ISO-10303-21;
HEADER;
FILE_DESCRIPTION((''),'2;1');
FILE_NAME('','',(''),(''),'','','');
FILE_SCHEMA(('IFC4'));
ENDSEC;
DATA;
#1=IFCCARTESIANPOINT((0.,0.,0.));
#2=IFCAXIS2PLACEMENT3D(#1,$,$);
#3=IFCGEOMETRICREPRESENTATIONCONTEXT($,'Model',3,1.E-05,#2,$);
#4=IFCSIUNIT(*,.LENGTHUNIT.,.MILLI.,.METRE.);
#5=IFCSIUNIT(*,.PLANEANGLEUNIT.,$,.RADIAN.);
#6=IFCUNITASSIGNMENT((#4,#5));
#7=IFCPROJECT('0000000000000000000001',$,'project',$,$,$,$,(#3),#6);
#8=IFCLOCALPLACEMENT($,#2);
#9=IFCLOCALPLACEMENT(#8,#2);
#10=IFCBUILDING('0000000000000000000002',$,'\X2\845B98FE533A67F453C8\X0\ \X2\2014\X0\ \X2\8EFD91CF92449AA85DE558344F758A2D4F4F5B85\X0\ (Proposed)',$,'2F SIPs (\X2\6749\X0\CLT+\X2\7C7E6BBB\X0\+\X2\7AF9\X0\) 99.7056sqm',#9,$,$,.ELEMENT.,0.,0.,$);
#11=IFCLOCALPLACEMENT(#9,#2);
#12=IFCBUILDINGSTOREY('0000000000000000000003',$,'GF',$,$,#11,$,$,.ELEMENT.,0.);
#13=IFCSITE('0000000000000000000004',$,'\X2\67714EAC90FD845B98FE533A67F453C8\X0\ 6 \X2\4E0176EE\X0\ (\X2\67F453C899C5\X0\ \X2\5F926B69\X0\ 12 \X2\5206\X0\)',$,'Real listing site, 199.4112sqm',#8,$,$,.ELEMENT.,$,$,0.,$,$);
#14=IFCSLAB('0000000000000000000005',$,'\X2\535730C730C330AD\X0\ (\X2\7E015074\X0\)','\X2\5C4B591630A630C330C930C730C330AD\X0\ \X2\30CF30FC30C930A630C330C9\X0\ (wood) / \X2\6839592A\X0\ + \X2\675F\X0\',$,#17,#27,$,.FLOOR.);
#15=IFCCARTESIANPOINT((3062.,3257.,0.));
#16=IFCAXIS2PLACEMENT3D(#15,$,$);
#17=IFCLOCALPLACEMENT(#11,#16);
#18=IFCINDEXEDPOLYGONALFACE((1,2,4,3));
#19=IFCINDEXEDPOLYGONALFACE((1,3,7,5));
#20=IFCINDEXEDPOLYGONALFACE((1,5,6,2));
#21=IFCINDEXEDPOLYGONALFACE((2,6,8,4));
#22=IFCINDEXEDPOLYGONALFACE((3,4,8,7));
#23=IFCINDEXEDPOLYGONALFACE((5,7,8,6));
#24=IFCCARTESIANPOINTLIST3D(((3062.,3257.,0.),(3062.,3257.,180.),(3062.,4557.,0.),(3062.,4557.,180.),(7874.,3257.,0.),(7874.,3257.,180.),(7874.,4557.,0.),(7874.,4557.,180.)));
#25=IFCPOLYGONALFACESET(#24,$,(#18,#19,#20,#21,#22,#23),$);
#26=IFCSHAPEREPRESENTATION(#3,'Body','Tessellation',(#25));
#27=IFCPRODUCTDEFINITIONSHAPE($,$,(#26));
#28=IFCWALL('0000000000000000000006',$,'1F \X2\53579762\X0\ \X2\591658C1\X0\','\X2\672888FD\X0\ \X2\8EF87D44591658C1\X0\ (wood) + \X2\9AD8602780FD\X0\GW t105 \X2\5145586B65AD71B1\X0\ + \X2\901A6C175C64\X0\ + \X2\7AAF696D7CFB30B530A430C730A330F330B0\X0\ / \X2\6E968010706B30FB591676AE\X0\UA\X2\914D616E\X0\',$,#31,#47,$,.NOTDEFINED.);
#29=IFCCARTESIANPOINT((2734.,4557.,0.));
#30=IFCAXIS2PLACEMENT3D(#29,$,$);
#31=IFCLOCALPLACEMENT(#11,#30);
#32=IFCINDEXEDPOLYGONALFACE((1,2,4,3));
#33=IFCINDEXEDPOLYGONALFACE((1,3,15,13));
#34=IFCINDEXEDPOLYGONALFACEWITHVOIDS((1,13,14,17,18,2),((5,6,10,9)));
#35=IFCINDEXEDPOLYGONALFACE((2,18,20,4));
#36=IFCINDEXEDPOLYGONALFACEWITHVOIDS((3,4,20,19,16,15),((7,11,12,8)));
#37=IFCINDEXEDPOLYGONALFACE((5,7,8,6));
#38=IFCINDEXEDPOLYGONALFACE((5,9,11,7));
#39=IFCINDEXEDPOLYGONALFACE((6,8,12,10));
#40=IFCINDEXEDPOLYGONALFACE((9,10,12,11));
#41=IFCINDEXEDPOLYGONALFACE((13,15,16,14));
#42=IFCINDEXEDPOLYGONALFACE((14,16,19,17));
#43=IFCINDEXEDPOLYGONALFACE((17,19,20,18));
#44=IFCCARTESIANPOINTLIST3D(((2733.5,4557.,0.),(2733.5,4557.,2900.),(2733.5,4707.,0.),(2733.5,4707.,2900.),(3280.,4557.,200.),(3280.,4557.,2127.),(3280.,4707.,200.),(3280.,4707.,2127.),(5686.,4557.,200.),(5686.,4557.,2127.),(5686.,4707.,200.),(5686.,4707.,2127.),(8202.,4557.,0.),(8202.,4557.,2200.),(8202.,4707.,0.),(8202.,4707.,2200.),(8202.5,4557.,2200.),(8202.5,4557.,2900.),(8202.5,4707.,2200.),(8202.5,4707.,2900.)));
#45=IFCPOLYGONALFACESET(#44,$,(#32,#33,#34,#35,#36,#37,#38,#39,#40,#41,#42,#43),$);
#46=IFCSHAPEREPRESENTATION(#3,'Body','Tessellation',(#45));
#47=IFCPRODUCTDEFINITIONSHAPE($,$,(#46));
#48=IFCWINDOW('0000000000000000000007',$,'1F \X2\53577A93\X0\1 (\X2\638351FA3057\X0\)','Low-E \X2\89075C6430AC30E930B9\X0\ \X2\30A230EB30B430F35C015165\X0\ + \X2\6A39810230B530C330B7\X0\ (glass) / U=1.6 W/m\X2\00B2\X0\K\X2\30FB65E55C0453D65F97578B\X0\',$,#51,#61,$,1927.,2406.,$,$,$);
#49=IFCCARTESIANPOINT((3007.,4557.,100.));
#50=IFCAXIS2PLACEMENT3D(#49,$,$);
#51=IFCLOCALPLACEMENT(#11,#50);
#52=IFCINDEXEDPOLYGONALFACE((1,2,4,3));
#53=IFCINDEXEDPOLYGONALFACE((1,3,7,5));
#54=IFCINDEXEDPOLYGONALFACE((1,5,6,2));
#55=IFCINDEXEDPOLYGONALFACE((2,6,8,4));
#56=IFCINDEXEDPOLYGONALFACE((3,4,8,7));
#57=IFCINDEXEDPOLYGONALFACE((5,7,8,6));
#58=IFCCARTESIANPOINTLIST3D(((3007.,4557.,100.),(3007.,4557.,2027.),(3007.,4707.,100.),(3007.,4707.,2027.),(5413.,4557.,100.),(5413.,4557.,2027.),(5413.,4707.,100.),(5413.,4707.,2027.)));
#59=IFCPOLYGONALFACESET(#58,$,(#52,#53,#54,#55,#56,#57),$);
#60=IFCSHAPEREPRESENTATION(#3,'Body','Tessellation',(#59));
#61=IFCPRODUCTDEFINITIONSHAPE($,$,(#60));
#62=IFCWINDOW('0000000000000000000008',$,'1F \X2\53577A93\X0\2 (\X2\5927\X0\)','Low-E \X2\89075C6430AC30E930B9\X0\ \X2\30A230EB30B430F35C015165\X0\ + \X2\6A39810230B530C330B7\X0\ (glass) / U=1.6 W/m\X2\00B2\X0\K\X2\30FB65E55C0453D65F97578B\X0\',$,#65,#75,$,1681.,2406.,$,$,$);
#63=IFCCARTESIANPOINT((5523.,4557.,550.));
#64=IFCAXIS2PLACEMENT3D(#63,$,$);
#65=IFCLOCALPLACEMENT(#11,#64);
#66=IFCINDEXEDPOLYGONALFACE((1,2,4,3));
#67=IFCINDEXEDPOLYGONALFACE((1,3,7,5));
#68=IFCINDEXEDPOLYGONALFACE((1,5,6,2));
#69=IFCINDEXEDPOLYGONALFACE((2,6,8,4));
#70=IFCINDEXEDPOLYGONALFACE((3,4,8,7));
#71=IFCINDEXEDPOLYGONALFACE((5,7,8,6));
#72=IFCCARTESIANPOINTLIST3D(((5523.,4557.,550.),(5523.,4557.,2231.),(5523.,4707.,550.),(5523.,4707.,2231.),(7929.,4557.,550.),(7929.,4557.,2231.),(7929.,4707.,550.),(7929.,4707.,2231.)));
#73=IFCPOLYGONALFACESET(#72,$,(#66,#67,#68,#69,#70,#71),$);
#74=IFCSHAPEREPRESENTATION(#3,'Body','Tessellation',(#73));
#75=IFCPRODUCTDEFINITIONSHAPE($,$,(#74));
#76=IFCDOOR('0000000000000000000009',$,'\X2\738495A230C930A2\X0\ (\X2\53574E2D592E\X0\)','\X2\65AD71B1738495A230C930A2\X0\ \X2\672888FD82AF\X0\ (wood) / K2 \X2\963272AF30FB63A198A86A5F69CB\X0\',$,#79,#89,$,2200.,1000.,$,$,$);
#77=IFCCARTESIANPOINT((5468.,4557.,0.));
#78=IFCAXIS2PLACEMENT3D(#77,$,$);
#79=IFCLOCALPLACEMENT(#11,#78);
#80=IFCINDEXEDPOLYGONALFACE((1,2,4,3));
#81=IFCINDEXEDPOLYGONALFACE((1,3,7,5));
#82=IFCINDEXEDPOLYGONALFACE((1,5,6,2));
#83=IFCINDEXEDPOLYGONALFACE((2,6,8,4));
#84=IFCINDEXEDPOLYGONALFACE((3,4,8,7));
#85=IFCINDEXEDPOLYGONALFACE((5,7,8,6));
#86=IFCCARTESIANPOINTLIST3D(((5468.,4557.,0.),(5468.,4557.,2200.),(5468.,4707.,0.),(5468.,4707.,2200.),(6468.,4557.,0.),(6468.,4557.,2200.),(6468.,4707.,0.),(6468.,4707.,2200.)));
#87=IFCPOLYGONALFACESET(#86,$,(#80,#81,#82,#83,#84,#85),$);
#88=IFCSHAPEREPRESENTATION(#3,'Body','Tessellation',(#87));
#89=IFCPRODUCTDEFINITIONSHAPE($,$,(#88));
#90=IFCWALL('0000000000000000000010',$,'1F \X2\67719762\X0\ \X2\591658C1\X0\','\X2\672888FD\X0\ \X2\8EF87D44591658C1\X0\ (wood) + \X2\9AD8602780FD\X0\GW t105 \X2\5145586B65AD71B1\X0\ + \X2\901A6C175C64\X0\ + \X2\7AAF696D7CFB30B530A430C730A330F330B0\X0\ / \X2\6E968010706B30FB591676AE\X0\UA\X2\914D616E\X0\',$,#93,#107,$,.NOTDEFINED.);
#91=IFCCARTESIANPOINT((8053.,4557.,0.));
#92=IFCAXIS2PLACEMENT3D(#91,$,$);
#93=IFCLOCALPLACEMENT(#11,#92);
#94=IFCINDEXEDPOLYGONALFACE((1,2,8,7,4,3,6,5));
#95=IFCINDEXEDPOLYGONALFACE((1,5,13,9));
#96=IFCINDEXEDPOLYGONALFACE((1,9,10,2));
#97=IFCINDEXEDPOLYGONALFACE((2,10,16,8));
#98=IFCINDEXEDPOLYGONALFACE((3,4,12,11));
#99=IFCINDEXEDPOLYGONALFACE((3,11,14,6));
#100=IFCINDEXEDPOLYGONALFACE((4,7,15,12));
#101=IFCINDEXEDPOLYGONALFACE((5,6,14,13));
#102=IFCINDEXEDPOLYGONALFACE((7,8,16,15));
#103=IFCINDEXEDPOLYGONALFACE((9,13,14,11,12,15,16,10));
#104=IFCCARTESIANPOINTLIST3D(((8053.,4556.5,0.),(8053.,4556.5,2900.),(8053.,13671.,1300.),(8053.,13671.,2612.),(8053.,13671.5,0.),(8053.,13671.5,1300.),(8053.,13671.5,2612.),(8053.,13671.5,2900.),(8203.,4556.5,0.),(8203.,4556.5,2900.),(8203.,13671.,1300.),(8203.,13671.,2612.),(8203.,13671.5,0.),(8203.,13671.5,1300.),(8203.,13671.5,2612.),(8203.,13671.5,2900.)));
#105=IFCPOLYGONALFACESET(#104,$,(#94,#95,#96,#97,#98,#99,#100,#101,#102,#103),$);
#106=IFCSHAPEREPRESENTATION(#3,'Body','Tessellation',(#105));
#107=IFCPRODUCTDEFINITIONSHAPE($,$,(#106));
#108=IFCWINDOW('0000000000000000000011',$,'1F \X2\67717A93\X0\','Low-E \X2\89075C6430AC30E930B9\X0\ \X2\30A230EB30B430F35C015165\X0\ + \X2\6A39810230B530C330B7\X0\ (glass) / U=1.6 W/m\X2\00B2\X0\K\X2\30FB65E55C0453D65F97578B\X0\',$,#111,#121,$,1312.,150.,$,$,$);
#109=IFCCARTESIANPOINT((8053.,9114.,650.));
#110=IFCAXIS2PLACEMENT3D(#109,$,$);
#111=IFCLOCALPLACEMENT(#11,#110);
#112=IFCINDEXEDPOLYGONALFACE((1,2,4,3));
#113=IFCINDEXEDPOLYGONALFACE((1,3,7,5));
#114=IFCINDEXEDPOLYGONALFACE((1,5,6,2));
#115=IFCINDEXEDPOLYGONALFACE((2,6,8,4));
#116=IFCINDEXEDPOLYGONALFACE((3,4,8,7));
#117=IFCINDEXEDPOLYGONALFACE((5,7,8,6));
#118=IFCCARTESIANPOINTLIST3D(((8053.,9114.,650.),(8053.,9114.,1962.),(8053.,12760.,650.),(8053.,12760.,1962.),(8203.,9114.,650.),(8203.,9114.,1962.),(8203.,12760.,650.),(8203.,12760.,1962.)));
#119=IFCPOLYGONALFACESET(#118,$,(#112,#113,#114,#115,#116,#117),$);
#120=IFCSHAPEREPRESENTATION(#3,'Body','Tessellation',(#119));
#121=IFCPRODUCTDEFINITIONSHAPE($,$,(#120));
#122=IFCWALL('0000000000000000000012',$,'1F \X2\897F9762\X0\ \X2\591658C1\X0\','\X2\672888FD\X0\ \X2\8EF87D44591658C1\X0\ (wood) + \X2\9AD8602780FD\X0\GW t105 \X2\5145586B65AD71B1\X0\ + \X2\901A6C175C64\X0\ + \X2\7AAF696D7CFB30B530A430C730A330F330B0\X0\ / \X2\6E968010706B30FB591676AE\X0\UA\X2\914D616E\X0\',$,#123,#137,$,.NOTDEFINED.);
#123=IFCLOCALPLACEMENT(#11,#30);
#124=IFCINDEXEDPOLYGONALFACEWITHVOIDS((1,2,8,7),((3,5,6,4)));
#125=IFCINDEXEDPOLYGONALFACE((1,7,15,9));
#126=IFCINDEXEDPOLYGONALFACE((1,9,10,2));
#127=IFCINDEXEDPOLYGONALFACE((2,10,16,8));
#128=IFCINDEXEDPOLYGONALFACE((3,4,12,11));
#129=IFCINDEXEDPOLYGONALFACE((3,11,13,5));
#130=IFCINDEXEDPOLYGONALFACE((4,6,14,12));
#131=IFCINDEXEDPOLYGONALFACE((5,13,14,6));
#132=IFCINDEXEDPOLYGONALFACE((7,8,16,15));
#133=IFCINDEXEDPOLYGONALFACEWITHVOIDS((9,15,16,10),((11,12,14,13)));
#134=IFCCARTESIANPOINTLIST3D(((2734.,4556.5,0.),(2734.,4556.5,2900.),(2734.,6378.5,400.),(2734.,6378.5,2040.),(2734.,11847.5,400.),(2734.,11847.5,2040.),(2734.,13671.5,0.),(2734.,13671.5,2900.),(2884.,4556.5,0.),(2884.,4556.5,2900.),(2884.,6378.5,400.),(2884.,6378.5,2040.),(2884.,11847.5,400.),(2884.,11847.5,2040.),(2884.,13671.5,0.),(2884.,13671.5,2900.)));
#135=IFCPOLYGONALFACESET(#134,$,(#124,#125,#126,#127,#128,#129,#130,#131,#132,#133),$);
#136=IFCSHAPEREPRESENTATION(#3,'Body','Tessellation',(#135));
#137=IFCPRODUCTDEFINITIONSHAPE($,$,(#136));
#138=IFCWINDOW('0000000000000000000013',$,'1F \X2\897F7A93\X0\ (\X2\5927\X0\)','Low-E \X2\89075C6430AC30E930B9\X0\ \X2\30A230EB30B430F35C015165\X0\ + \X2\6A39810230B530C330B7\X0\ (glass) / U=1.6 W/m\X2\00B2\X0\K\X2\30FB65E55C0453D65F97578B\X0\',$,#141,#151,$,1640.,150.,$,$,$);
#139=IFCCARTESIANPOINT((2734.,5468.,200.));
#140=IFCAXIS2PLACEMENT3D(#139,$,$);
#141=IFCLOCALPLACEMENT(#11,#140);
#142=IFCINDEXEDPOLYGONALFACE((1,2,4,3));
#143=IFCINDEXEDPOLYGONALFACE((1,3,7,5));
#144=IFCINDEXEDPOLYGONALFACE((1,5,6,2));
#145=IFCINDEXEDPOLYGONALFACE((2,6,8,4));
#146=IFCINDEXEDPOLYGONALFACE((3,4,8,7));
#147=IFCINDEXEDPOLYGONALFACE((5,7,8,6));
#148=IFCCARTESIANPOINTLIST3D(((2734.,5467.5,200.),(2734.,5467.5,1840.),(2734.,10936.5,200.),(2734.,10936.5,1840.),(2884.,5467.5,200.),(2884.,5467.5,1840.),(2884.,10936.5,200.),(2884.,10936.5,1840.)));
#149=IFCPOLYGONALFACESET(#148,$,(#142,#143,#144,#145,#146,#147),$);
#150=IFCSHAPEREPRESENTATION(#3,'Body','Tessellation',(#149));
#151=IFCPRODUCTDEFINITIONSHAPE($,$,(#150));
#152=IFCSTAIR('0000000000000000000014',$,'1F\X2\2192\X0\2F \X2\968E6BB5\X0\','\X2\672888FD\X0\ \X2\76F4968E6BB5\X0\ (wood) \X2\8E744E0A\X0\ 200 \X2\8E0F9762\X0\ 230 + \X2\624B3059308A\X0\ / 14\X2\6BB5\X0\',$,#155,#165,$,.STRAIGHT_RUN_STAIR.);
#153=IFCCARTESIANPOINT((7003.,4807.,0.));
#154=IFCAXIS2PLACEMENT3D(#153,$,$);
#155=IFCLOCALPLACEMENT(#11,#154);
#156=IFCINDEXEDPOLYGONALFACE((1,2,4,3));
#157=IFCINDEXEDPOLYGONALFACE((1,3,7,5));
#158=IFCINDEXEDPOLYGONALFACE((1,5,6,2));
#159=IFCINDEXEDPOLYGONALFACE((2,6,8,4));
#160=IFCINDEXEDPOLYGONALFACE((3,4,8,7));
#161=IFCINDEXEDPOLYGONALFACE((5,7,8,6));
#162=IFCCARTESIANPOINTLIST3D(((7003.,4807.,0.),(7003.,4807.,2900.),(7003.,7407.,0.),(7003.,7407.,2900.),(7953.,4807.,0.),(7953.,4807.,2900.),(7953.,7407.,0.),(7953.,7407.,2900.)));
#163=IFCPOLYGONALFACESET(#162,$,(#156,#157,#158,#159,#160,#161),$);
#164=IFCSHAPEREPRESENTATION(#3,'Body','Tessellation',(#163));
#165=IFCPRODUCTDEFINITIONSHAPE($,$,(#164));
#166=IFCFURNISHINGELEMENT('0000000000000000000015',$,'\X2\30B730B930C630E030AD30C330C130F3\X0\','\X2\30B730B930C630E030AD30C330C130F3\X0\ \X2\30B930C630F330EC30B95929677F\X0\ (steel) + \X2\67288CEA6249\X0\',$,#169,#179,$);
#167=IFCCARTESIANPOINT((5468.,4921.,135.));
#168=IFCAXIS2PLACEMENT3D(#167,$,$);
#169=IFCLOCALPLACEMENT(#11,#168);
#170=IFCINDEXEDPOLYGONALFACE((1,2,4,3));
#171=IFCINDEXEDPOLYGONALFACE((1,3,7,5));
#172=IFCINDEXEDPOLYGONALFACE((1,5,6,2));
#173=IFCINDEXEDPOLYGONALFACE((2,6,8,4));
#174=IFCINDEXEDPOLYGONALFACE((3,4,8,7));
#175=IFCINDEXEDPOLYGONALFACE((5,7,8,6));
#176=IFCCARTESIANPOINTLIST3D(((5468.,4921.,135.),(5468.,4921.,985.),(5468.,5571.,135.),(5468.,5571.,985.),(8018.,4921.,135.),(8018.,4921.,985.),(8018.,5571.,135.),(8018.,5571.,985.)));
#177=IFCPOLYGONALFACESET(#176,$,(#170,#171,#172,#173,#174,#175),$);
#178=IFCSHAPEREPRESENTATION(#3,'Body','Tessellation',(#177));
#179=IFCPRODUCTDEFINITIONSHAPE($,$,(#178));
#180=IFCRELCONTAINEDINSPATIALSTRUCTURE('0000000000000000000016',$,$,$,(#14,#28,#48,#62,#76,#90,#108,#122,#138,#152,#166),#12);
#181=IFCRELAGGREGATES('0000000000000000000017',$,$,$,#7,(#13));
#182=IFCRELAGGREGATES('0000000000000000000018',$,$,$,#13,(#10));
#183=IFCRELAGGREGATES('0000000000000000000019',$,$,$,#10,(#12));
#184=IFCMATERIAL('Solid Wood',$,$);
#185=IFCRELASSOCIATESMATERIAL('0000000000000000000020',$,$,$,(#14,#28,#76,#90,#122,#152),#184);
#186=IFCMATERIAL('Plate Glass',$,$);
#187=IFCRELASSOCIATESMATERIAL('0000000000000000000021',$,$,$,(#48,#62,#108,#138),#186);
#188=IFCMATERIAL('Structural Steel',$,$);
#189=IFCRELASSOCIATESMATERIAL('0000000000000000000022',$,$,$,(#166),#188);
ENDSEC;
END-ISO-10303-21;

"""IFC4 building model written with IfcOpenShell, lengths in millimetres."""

from ifc_helpers import new_model, si_unit, frame, frame_2d, origin, place, context, project, spatial, rectangle, extrude, material, element, fill, save


model = new_model("IFC4")

# Units and contexts
model_context = context("Model", 3, precision=1e-05, world=origin())
ifc_project = project(units=[si_unit("LENGTHUNIT", "METRE", prefix="MILLI"), si_unit("PLANEANGLEUNIT", "RADIAN")], contexts=[model_context])

# Site, building, storey
site_placement = place(None, origin())
site = spatial("IfcSite", under=ifc_project, at=site_placement, Name="東京都葛飾区柴又 6 丁目 (柴又駅 徒歩 12 分)", ObjectType="Real listing site, 199.4112sqm", CompositionType="ELEMENT", RefElevation=0.0)
building_placement = place(site_placement, origin())
building = spatial("IfcBuilding", under=site, at=building_placement, Name="葛飾区柴又 — 軽量鉄骨工場併設住宅 (Proposed)", ObjectType="2F SIPs (杉CLT+籾殻+竹) 99.7056sqm", CompositionType="ELEMENT", ElevationOfRefHeight=0.0, ElevationOfTerrain=0.0)
storey_placement = place(building_placement, origin())
storey = spatial("IfcBuildingStorey", under=building, at=storey_placement, Name="GF", CompositionType="ELEMENT", Elevation=0.0)

# Slab
ifc_material_1 = material(Name="Solid Wood")
slab_1_placement = place(storey_placement, frame((3062.0, 3257.0, 0.0)))
element("IfcSlab", 1, at=slab_1_placement, inside=storey, material=ifc_material_1, Name="南デッキ (縁側)", Description="屋外ウッドデッキ ハードウッド (wood) / 根太 + 束", PredefinedType="FLOOR", context=model_context, shape_type="SweptSolid", body=[
    extrude(rectangle(XDim=4812.0, YDim=1300.0, at=frame_2d((2406.0, 650.0))), frame((3062.0, 3257.0, 0.0)), (0.0, 0.0, 1.0), 180.0),
])

# Wall, openings, windows, door
wall_1_placement = place(storey_placement, frame((2734.0, 4557.0, 0.0)))
wall_1 = element("IfcWall", 2, at=wall_1_placement, inside=storey, material=ifc_material_1, Name="1F 南面 外壁", Description="木製 軸組外壁 (wood) + 高性能GW t105 充填断熱 + 通気層 + 窯業系サイディング / 準耐火・外皮UA配慮", PredefinedType="NOTDEFINED", context=model_context, shape_type="SweptSolid", body=[
    extrude(rectangle(XDim=5469.0, YDim=150.0, at=frame_2d((2734.0, 75.0))), frame((2734.0, 4557.0, 0.0)), (0.0, 0.0, 1.0), 2900.0),
])
opening_1_placement = place(storey_placement, frame((3007.0, 4557.0, 100.0)))
opening_1 = element("IfcOpeningElement", 3, at=opening_1_placement, cuts=wall_1, PredefinedType="NOTDEFINED", context=model_context, shape_type="SweptSolid", body=[
    extrude(rectangle(XDim=2406.0, YDim=150.0, at=frame_2d((1203.0, 75.0))), frame((3007.0, 4557.0, 100.0)), (0.0, 0.0, 1.0), 1927.0),
])
opening_2_placement = place(storey_placement, frame((5523.0, 4557.0, 550.0)))
opening_2 = element("IfcOpeningElement", 4, at=opening_2_placement, cuts=wall_1, PredefinedType="NOTDEFINED", context=model_context, shape_type="SweptSolid", body=[
    extrude(rectangle(XDim=2406.0, YDim=150.0, at=frame_2d((1203.0, 75.0))), frame((5523.0, 4557.0, 550.0)), (0.0, 0.0, 1.0), 1681.0),
])
opening_3_placement = place(storey_placement, frame((5468.0, 4557.0, 0.0)))
opening_3 = element("IfcOpeningElement", 5, at=opening_3_placement, cuts=wall_1, PredefinedType="NOTDEFINED", context=model_context, shape_type="SweptSolid", body=[
    extrude(rectangle(XDim=1000.0, YDim=150.0, at=frame_2d((500.0, 75.0))), frame((5468.0, 4557.0, 0.0)), (0.0, 0.0, 1.0), 2200.0),
])
ifc_material_2 = material(Name="Plate Glass")
window_1_placement = place(storey_placement, frame((3007.0, 4557.0, 100.0)))
window_1 = element("IfcWindow", 6, at=window_1_placement, inside=storey, material=ifc_material_2, Name="1F 南窓1 (掃出し)", Description="Low-E 複層ガラス アルゴン封入 + 樹脂サッシ (glass) / U=1.6 W/m²K・日射取得型", OverallHeight=1927.0, OverallWidth=2406.0, context=model_context, shape_type="SweptSolid", body=[
    extrude(rectangle(XDim=2406.0, YDim=150.0, at=frame_2d((1203.0, 75.0))), frame((3007.0, 4557.0, 100.0)), (0.0, 0.0, 1.0), 1927.0),
])
fill(opening_1, window_1)
window_2_placement = place(storey_placement, frame((5523.0, 4557.0, 550.0)))
window_2 = element("IfcWindow", 7, at=window_2_placement, inside=storey, material=ifc_material_2, Name="1F 南窓2 (大)", Description="Low-E 複層ガラス アルゴン封入 + 樹脂サッシ (glass) / U=1.6 W/m²K・日射取得型", OverallHeight=1681.0, OverallWidth=2406.0, context=model_context, shape_type="SweptSolid", body=[
    extrude(rectangle(XDim=2406.0, YDim=150.0, at=frame_2d((1203.0, 75.0))), frame((5523.0, 4557.0, 550.0)), (0.0, 0.0, 1.0), 1681.0),
])
fill(opening_2, window_2)
door_placement = place(storey_placement, frame((5468.0, 4557.0, 0.0)))
door = element("IfcDoor", 8, at=door_placement, inside=storey, material=ifc_material_1, Name="玄関ドア (南中央)", Description="断熱玄関ドア 木製芯 (wood) / K2 防犯・採風機構", OverallHeight=2200.0, OverallWidth=1000.0, context=model_context, shape_type="SweptSolid", body=[
    extrude(rectangle(XDim=1000.0, YDim=150.0, at=frame_2d((500.0, 75.0))), frame((5468.0, 4557.0, 0.0)), (0.0, 0.0, 1.0), 2200.0),
])
fill(opening_3, door)

# Walls, openings, windows
wall_2_placement = place(storey_placement, frame((8053.0, 4557.0, 0.0)))
wall_2 = element("IfcWall", 9, at=wall_2_placement, inside=storey, material=ifc_material_1, Name="1F 東面 外壁", Description="木製 軸組外壁 (wood) + 高性能GW t105 充填断熱 + 通気層 + 窯業系サイディング / 準耐火・外皮UA配慮", PredefinedType="NOTDEFINED", context=model_context, shape_type="SweptSolid", body=[
    extrude(rectangle(XDim=150.0, YDim=9115.0, at=frame_2d((75.0, 4557.0))), frame((8053.0, 4557.0, 0.0)), (0.0, 0.0, 1.0), 2900.0),
])
opening_4_placement = place(storey_placement, frame((8053.0, 9114.0, 650.0)))
opening_4 = element("IfcOpeningElement", 10, at=opening_4_placement, cuts=wall_2, PredefinedType="NOTDEFINED", context=model_context, shape_type="SweptSolid", body=[
    extrude(rectangle(XDim=150.0, YDim=3646.0, at=frame_2d((75.0, 1823.0))), frame((8053.0, 9114.0, 650.0)), (0.0, 0.0, 1.0), 1312.0),
])
window_3_placement = place(storey_placement, frame((8053.0, 9114.0, 650.0)))
window_3 = element("IfcWindow", 11, at=window_3_placement, inside=storey, material=ifc_material_2, Name="1F 東窓", Description="Low-E 複層ガラス アルゴン封入 + 樹脂サッシ (glass) / U=1.6 W/m²K・日射取得型", OverallHeight=1312.0, OverallWidth=150.0, context=model_context, shape_type="SweptSolid", body=[
    extrude(rectangle(XDim=150.0, YDim=3646.0, at=frame_2d((75.0, 1823.0))), frame((8053.0, 9114.0, 650.0)), (0.0, 0.0, 1.0), 1312.0),
])
fill(opening_4, window_3)
wall_3_placement = place(storey_placement, frame((2734.0, 4557.0, 0.0)))
wall_3 = element("IfcWall", 12, at=wall_3_placement, inside=storey, material=ifc_material_1, Name="1F 西面 外壁", Description="木製 軸組外壁 (wood) + 高性能GW t105 充填断熱 + 通気層 + 窯業系サイディング / 準耐火・外皮UA配慮", PredefinedType="NOTDEFINED", context=model_context, shape_type="SweptSolid", body=[
    extrude(rectangle(XDim=150.0, YDim=9115.0, at=frame_2d((75.0, 4557.0))), frame((2734.0, 4557.0, 0.0)), (0.0, 0.0, 1.0), 2900.0),
])
opening_5_placement = place(storey_placement, frame((2734.0, 5468.0, 200.0)))
opening_5 = element("IfcOpeningElement", 13, at=opening_5_placement, cuts=wall_3, PredefinedType="NOTDEFINED", context=model_context, shape_type="SweptSolid", body=[
    extrude(rectangle(XDim=150.0, YDim=5469.0, at=frame_2d((75.0, 2734.0))), frame((2734.0, 5468.0, 200.0)), (0.0, 0.0, 1.0), 1640.0),
])
window_4_placement = place(storey_placement, frame((2734.0, 5468.0, 200.0)))
window_4 = element("IfcWindow", 14, at=window_4_placement, inside=storey, material=ifc_material_2, Name="1F 西窓 (大)", Description="Low-E 複層ガラス アルゴン封入 + 樹脂サッシ (glass) / U=1.6 W/m²K・日射取得型", OverallHeight=1640.0, OverallWidth=150.0, context=model_context, shape_type="SweptSolid", body=[
    extrude(rectangle(XDim=150.0, YDim=5469.0, at=frame_2d((75.0, 2734.0))), frame((2734.0, 5468.0, 200.0)), (0.0, 0.0, 1.0), 1640.0),
])
fill(opening_5, window_4)

# Stair
stair_placement = place(storey_placement, frame((7003.0, 4807.0, 0.0)))
element("IfcStair", 15, at=stair_placement, inside=storey, material=ifc_material_1, Name="1F→2F 階段", Description="木製 直階段 (wood) 蹴上 200 踏面 230 + 手すり / 14段", PredefinedType="STRAIGHT_RUN_STAIR", context=model_context, shape_type="SweptSolid", body=[
    extrude(rectangle(XDim=950.0, YDim=2600.0, at=frame_2d((475.0, 1300.0))), frame((7003.0, 4807.0, 0.0)), (0.0, 0.0, 1.0), 2900.0),
])

# Furnishing element
ifc_material_3 = material(Name="Structural Steel")
furnishing_placement = place(storey_placement, frame((5468.0, 4921.0, 135.0)))
element("IfcFurnishingElement", 16, at=furnishing_placement, inside=storey, material=ifc_material_3, Name="システムキッチン", Description="システムキッチン ステンレス天板 (steel) + 木質扉", context=model_context, shape_type="SweptSolid", body=[
    extrude(rectangle(XDim=2550.0, YDim=650.0, at=frame_2d((1275.0, 325.0))), frame((5468.0, 4921.0, 135.0)), (0.0, 0.0, 1.0), 850.0),
])

save(model, "model.ifc")
